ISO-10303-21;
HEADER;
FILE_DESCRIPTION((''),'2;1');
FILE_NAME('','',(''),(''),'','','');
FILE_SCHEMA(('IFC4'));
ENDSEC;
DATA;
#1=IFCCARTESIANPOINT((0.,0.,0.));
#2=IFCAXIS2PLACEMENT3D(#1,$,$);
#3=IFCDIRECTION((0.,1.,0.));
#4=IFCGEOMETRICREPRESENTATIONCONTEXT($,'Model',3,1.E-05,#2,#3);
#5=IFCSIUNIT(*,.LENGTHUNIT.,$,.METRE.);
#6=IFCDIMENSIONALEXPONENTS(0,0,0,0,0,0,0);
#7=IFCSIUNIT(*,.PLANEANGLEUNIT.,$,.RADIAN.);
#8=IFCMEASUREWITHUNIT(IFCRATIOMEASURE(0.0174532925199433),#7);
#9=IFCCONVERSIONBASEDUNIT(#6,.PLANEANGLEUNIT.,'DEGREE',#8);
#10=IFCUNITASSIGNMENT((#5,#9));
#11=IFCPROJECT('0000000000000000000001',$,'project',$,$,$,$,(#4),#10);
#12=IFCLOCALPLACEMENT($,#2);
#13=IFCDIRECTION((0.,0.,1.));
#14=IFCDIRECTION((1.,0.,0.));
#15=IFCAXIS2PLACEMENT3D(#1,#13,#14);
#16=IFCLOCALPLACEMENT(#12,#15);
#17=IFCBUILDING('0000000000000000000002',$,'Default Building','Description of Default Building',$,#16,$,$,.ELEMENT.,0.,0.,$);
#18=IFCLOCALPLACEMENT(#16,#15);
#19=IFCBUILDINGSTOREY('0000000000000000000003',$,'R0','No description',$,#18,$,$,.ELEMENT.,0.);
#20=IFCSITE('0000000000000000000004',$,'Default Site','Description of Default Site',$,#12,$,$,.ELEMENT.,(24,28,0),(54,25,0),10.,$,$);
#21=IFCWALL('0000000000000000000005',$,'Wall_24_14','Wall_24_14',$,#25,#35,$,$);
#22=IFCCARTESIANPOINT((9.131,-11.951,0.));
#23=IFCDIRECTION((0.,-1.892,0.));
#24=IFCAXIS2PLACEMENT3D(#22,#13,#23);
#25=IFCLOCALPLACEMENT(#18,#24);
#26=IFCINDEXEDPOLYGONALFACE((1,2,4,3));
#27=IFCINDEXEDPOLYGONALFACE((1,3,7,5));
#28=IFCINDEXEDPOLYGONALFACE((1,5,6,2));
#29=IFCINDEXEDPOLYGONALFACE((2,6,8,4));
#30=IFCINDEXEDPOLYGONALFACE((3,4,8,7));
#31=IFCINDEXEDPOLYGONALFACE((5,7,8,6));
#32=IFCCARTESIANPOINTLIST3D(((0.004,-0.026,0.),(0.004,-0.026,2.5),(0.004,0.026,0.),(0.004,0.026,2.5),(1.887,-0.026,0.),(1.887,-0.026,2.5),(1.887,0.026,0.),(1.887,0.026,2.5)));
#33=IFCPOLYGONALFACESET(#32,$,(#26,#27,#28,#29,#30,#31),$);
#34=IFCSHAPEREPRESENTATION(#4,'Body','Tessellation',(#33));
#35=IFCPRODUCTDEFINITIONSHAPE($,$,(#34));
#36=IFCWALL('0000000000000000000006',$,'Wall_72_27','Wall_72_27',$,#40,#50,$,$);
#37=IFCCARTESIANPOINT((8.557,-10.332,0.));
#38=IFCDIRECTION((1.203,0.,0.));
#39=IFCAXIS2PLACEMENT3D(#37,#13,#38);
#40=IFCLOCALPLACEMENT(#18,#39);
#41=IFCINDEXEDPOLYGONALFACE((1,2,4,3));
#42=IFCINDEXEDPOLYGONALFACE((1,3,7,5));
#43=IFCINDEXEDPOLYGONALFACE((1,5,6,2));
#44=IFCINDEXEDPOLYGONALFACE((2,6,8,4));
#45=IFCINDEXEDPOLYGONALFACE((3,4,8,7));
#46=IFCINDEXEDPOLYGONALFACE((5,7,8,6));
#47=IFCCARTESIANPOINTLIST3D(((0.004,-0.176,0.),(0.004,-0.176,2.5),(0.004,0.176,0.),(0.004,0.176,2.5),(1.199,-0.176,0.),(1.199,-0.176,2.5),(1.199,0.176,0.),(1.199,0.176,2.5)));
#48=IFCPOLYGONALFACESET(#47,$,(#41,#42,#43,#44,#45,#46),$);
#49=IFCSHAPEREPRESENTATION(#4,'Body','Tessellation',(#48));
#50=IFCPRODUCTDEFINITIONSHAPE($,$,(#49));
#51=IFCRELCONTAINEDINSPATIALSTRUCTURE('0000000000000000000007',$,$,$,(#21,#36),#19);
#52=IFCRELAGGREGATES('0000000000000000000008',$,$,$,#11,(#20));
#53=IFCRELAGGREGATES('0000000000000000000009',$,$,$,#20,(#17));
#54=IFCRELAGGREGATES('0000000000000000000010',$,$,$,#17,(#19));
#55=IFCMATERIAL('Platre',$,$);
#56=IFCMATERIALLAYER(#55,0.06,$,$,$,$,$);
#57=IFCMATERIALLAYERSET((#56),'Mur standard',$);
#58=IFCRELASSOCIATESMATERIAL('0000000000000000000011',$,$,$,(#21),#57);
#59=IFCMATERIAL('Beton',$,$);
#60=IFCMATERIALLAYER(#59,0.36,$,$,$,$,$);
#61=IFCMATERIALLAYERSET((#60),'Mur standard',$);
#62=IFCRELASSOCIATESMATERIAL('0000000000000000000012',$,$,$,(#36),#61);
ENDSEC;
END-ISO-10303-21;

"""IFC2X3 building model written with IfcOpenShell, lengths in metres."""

from ifc_helpers import new_model, entity, si_unit, converted_unit, direction, frame, origin, origin_with_axes, place, context, project, spatial, polyline, outline, extrude, material, layer, layer_set, layer_usage, element, save


model = new_model("IFC2X3")

# Units and contexts
model_context = context("Model", 3, precision=1e-05, world=origin(), true_north=direction((0.0, 1.0, 0.0)))
ifc_project = project(units=[si_unit("LENGTHUNIT", "METRE"), converted_unit("PLANEANGLEUNIT", "DEGREE", entity("IfcRatioMeasure", 0.0174532925199433), si_unit("PLANEANGLEUNIT", "RADIAN"), dimensions=[0, 0, 0, 0, 0, 0, 0])], contexts=[model_context])

# Site, building, storey
site_placement = place(None, origin())
site = spatial("IfcSite", under=ifc_project, at=site_placement, Name="Default Site", Description="Description of Default Site", CompositionType="ELEMENT", RefLatitude=(24, 28, 0), RefLongitude=(54, 25, 0), RefElevation=10.0)
building_placement = place(site_placement, origin_with_axes())
building = spatial("IfcBuilding", under=site, at=building_placement, Name="Default Building", Description="Description of Default Building", CompositionType="ELEMENT", ElevationOfRefHeight=0.0, ElevationOfTerrain=0.0)
storey_placement = place(building_placement, origin_with_axes())
storey = spatial("IfcBuildingStorey", under=building, at=storey_placement, Name="R0", Description="No description", CompositionType="ELEMENT", Elevation=0.0)

# Shared definitions
ifc_material_1 = material(Name="Beton")
ifc_layer_1 = layer(ifc_material_1, 0.36)
ifc_layer_set_1 = layer_set([ifc_layer_1], Name="Mur standard")
ifc_layer_usage_1 = layer_usage(ifc_layer_set_1, "AXIS2", "NEGATIVE", 0.36)

# Shared definitions
ifc_material_2 = material(Name="Platre")
ifc_layer_2 = layer(ifc_material_2, 0.06)
ifc_layer_set_2 = layer_set([ifc_layer_2], Name="Mur standard")
ifc_layer_usage_2 = layer_usage(ifc_layer_set_2, "AXIS2", "NEGATIVE", 0.06)

# Wall
wall_1_placement = place(storey_placement, frame((9.131, -11.951, 0.0), z_axis=(0.0, 0.0, 1.0), x_axis=(0.0, -1.892, 0.0)))
element("IfcWall", 1, at=wall_1_placement, inside=storey, material=ifc_layer_usage_2, Name="Wall_24_14", Description="Wall_24_14", context=model_context, shape_type="SweptSolid", body=[
    extrude(outline(polyline([(0.004, -0.026), (1.887, -0.026), (1.887, 0.026), (0.004, 0.026), (0.004, -0.026)])), origin(), (0.0, 0.0, 1.0), 2.5),
])

# Wall
wall_2_placement = place(storey_placement, frame((8.557, -10.332, 0.0), z_axis=(0.0, 0.0, 1.0), x_axis=(1.203, 0.0, 0.0)))
element("IfcWall", 2, at=wall_2_placement, inside=storey, material=ifc_layer_usage_1, Name="Wall_72_27", Description="Wall_72_27", context=model_context, shape_type="SweptSolid", body=[
    extrude(outline(polyline([(0.004, 0.176), (0.004, -0.176), (1.199, -0.176), (1.199, 0.176), (0.004, 0.176)])), origin(), (0.0, 0.0, 1.0), 2.5),
])

save(model, "model.ifc")
